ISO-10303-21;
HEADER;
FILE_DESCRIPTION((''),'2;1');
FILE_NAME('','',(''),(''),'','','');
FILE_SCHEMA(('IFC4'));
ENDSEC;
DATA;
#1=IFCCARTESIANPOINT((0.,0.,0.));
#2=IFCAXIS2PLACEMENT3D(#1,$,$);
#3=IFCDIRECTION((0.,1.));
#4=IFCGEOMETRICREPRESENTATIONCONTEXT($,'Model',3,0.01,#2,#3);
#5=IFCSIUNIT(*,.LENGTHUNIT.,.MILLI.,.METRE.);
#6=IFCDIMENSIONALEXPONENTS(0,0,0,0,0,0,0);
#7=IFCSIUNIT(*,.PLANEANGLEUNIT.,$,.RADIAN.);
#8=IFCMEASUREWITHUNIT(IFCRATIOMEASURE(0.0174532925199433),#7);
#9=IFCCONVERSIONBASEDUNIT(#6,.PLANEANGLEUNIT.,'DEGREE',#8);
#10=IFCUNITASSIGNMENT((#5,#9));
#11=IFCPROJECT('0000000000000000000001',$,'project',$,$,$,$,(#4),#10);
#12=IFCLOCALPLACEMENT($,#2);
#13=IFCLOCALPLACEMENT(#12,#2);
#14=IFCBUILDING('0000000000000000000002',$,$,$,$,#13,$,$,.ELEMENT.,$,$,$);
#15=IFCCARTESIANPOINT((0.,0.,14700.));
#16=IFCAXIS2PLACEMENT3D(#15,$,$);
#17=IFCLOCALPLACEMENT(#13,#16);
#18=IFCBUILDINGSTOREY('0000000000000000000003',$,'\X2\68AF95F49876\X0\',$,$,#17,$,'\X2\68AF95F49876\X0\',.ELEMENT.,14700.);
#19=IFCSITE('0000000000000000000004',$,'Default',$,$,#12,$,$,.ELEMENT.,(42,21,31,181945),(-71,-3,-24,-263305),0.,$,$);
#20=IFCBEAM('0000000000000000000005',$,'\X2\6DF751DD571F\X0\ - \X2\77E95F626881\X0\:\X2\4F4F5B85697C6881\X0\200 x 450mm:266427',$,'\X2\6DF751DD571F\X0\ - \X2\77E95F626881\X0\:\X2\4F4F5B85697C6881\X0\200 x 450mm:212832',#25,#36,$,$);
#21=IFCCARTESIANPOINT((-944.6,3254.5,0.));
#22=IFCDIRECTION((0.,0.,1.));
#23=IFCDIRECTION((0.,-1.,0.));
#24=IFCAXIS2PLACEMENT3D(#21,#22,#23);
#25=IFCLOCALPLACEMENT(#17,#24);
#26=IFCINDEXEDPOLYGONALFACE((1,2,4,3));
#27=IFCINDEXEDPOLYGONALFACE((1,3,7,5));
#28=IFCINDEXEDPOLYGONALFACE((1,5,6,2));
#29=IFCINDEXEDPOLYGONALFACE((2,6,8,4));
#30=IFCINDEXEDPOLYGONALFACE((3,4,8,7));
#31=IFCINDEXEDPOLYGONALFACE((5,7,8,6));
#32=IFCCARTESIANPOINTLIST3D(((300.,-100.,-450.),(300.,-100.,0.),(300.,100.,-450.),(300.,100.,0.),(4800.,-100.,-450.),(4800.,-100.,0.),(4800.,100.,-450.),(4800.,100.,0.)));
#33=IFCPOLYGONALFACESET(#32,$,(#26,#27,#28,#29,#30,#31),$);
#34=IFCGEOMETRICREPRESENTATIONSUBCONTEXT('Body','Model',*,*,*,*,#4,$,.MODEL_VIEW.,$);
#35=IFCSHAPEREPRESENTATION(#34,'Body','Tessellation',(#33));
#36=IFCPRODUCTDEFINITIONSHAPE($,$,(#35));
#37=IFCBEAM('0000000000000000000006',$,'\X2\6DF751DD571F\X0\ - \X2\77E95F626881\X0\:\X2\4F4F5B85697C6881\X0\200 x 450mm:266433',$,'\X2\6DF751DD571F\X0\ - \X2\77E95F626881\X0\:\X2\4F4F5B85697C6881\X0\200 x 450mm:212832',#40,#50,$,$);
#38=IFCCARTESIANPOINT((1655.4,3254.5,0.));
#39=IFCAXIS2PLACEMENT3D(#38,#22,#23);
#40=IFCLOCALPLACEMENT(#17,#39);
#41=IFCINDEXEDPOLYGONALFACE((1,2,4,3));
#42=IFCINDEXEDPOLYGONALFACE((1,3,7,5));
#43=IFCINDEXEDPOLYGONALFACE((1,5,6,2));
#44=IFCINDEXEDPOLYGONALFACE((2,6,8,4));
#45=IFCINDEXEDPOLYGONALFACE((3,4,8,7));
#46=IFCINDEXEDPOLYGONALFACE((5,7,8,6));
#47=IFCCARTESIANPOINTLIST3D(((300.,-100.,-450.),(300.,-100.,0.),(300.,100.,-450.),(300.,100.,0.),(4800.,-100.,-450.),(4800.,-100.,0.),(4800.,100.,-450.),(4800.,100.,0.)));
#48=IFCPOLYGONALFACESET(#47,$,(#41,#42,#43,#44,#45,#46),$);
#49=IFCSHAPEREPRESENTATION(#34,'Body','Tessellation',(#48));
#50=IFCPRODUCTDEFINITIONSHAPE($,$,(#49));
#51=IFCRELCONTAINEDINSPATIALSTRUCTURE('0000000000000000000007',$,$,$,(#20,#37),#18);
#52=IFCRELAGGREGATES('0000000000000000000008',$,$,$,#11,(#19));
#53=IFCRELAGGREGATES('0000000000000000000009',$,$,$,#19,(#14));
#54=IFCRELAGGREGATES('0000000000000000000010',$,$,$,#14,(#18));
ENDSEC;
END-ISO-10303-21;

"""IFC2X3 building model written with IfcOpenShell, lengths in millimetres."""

from ifc_helpers import new_model, entity, si_unit, converted_unit, direction, frame, frame_2d, origin, place, context, subcontext, project, spatial, rectangle, extrude, element, save


model = new_model("IFC2X3")

# Units and contexts
model_context = context("Model", 3, precision=0.01, world=origin(), true_north=direction((0.0, 1.0)))
body_context = subcontext(model_context, "Body", "Model", "MODEL_VIEW")
ifc_project = project(units=[si_unit("LENGTHUNIT", "METRE", prefix="MILLI"), converted_unit("PLANEANGLEUNIT", "DEGREE", entity("IfcRatioMeasure", 0.0174532925199433), si_unit("PLANEANGLEUNIT", "RADIAN"), dimensions=[0, 0, 0, 0, 0, 0, 0])], contexts=[model_context])

# Site, building, storey
site_placement = place(None, origin())
site = spatial("IfcSite", under=ifc_project, at=site_placement, Name="Default", CompositionType="ELEMENT", RefLatitude=(42, 21, 31, 181945), RefLongitude=(-71, -3, -24, -263305), RefElevation=0.0)
building_placement = place(site_placement, origin())
building = spatial("IfcBuilding", under=site, at=building_placement, CompositionType="ELEMENT")
storey_placement = place(building_placement, frame((0.0, 0.0, 14700.0)))
storey = spatial("IfcBuildingStorey", under=building, at=storey_placement, Name="梯间顶", LongName="梯间顶", CompositionType="ELEMENT", Elevation=14700.0)

# Beams
beam_1_placement = place(storey_placement, frame((-944.6, 3254.5, 0.0), z_axis=(0.0, 0.0, 1.0), x_axis=(0.0, -1.0, 0.0)))
element("IfcBeam", 1, at=beam_1_placement, inside=storey, Name="混凝土 - 矩形梁:住宅楼梁200 x 450mm:266427", ObjectType="混凝土 - 矩形梁:住宅楼梁200 x 450mm:212832", context=body_context, shape_type="SweptSolid", body=[
    extrude(rectangle(XDim=450.0, YDim=200.0, at=frame_2d((0.0, 0.0), x_axis=(1.0, 0.0))), frame((300.0, 0.0, -225.0), z_axis=(1.0, 0.0, 0.0), x_axis=(0.0, 0.0, -1.0)), (0.0, 0.0, 1.0), 4500.0),
])
beam_2_placement = place(storey_placement, frame((1655.4, 3254.5, 0.0), z_axis=(0.0, 0.0, 1.0), x_axis=(0.0, -1.0, 0.0)))
element("IfcBeam", 2, at=beam_2_placement, inside=storey, Name="混凝土 - 矩形梁:住宅楼梁200 x 450mm:266433", ObjectType="混凝土 - 矩形梁:住宅楼梁200 x 450mm:212832", context=body_context, shape_type="SweptSolid", body=[
    extrude(rectangle(XDim=450.0, YDim=200.0, at=frame_2d((0.0, 0.0), x_axis=(1.0, 0.0))), frame((300.0, 0.0, -225.0), z_axis=(1.0, 0.0, 0.0), x_axis=(0.0, 0.0, -1.0)), (0.0, 0.0, 1.0), 4500.0),
])

save(model, "model.ifc")
